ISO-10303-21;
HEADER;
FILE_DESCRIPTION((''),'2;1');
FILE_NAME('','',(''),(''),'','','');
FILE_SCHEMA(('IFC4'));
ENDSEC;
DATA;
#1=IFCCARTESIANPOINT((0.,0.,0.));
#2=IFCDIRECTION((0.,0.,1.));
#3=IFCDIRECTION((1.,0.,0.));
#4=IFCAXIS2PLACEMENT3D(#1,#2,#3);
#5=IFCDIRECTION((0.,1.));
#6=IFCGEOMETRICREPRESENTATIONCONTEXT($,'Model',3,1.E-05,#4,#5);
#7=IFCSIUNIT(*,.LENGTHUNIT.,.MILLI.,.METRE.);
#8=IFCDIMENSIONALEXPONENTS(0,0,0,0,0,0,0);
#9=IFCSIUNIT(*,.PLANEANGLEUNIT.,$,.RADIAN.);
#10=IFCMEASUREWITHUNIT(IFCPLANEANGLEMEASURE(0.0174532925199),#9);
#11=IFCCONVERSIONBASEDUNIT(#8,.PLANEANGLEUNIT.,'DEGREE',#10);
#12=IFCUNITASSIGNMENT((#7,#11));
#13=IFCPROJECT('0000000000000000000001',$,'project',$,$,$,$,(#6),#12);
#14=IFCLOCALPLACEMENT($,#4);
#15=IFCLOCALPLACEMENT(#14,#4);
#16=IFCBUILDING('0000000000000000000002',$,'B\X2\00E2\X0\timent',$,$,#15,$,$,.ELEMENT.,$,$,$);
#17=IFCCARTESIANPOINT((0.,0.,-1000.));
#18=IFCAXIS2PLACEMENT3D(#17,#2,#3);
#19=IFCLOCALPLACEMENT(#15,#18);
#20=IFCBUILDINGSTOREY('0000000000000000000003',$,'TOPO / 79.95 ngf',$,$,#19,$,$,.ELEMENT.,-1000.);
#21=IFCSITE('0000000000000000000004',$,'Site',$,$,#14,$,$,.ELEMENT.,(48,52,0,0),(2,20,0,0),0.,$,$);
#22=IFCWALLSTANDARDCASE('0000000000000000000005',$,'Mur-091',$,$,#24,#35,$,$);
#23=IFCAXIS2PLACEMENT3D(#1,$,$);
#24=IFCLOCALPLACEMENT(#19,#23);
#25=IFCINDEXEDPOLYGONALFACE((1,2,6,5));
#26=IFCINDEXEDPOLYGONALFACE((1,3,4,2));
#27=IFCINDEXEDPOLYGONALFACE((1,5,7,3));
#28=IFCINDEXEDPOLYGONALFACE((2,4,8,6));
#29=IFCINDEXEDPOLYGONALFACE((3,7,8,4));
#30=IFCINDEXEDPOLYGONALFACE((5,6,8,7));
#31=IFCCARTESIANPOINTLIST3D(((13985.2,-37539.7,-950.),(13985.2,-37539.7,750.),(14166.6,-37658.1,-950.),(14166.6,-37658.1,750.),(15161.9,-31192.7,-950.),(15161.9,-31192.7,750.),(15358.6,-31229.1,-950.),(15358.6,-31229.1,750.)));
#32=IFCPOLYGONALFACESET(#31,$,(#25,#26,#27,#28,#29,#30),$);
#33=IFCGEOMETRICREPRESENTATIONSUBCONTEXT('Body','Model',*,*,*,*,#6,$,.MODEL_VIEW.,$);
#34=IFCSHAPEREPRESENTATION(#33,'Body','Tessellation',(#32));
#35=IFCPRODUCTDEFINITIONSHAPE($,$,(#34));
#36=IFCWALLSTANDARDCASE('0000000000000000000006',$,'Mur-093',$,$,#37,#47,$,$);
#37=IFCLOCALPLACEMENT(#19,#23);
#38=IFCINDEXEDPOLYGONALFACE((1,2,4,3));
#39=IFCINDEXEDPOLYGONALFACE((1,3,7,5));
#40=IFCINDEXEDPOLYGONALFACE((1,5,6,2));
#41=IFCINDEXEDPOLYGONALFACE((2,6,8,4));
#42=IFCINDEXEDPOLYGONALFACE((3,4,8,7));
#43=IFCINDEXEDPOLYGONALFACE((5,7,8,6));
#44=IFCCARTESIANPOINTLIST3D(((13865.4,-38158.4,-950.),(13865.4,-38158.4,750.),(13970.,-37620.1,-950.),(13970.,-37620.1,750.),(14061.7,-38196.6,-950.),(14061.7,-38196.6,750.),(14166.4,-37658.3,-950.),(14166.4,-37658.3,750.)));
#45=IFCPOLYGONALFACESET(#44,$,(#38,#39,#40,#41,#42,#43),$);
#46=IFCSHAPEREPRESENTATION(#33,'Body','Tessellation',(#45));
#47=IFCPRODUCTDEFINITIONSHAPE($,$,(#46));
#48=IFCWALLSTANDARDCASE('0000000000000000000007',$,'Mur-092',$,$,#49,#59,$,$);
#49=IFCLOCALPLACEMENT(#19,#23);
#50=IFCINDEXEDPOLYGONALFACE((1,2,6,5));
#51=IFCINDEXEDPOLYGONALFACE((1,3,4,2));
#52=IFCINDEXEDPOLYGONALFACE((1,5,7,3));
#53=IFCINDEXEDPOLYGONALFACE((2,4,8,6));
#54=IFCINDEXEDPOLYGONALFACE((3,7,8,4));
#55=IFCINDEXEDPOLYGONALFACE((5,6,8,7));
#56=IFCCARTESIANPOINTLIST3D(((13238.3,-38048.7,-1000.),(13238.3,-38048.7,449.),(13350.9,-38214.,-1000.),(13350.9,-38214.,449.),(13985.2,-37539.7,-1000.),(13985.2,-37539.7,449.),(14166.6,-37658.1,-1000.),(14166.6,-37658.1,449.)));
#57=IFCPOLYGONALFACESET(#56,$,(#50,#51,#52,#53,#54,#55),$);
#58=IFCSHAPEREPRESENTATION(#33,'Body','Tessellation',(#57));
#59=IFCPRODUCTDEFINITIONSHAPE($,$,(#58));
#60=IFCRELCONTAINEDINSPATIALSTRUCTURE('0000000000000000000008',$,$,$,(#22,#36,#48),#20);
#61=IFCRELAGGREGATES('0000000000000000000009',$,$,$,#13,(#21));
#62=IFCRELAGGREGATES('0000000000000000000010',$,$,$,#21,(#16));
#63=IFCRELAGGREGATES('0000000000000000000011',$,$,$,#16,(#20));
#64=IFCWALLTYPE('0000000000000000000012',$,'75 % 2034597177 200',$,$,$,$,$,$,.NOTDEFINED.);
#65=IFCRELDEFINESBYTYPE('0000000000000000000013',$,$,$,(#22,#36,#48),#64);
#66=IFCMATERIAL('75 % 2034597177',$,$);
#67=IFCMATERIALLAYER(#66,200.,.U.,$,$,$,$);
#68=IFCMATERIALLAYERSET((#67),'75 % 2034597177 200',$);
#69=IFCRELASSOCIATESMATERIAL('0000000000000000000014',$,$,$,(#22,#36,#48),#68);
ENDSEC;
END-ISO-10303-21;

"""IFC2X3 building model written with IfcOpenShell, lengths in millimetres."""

from ifc_helpers import new_model, entity, si_unit, converted_unit, direction, frame, origin_with_axes, place, context, subcontext, project, spatial, polyline, outline, extrude, material, layer, layer_set, layer_usage, type_object, element, save


model = new_model("IFC2X3")

# Units and contexts
model_context = context("Model", 3, precision=1e-05, world=origin_with_axes(), true_north=direction((0.0, 1.0)))
body_context = subcontext(model_context, "Body", "Model", "MODEL_VIEW")
ifc_project = project(units=[si_unit("LENGTHUNIT", "METRE", prefix="MILLI"), converted_unit("PLANEANGLEUNIT", "DEGREE", entity("IfcPlaneAngleMeasure", 0.0174532925199), si_unit("PLANEANGLEUNIT", "RADIAN"), dimensions=[0, 0, 0, 0, 0, 0, 0])], contexts=[model_context])

# Site, building, storey
site_placement = place(None, origin_with_axes())
site = spatial("IfcSite", under=ifc_project, at=site_placement, Name="Site", CompositionType="ELEMENT", RefLatitude=(48, 52, 0, 0), RefLongitude=(2, 20, 0, 0), RefElevation=0.0)
building_placement = place(site_placement, origin_with_axes())
building = spatial("IfcBuilding", under=site, at=building_placement, Name="Bâtiment", CompositionType="ELEMENT")
storey_placement = place(building_placement, frame((0.0, 0.0, -1000.0), z_axis=(0.0, 0.0, 1.0), x_axis=(1.0, 0.0, 0.0)))
storey = spatial("IfcBuildingStorey", under=building, at=storey_placement, Name="TOPO / 79.95 ngf", CompositionType="ELEMENT", Elevation=-1000.0)

# Walls
ifc_material_1 = material(Name="75 % 2034597177")
ifc_layer_1 = layer(ifc_material_1, 200.0, ventilated="UNKNOWN")
ifc_layer_set_1 = layer_set([ifc_layer_1], Name="75 % 2034597177 200")
ifc_layer_usage_1 = layer_usage(ifc_layer_set_1, "AXIS2", "NEGATIVE", 200.0)
wall_type_1 = type_object("IfcWallType", Name="75 % 2034597177 200", PredefinedType="NOTDEFINED")
wall_1_placement = place(storey_placement, frame((15161.9, -31192.7, -950.0), z_axis=(0.0, 0.0, 1.0), x_axis=(-0.182296, -0.983244, 0.0)))
element("IfcWallStandardCase", 1, at=wall_1_placement, inside=storey, type_object=wall_type_1, material=ifc_layer_usage_1, Name="Mur-091", context=body_context, shape_type="SweptSolid", body=[
    extrude(outline(polyline([(0.0, 0.0), (6455.2, 0.0), (6538.5, 200.0), (0.0, 200.0), (0.0, 0.0)])), origin_with_axes(), (0.0, 0.0, 1.0), 1700.0),
])
ifc_layer_usage_2 = layer_usage(ifc_layer_set_1, "AXIS2", "POSITIVE", -200.0)
wall_2_placement = place(storey_placement, frame((14166.4, -37658.3, -950.0), z_axis=(0.0, 0.0, 1.0), x_axis=(-0.190862, -0.981617, 0.0)))
element("IfcWallStandardCase", 2, at=wall_2_placement, inside=storey, type_object=wall_type_1, material=ifc_layer_usage_2, Name="Mur-093", context=body_context, shape_type="SweptSolid", body=[
    extrude(outline(polyline([(0.0, -200.0), (548.4, -200.0), (548.4, 0.0), (0.0, 0.0), (0.0, -200.0)])), origin_with_axes(), (0.0, 0.0, 1.0), 1700.0),
])
ifc_layer_usage_3 = layer_usage(ifc_layer_set_1, "AXIS2", "NEGATIVE", 200.0)
wall_3_placement = place(storey_placement, frame((13985.2, -37539.7, -1000.0), z_axis=(0.0, 0.0, 1.0), x_axis=(-0.826372, -0.563124, 0.0)))
element("IfcWallStandardCase", 3, at=wall_3_placement, inside=storey, type_object=wall_type_1, material=ifc_layer_usage_3, Name="Mur-092", context=body_context, shape_type="SweptSolid", body=[
    extrude(outline(polyline([(0.0, 0.0), (903.9, 0.0), (903.9, 200.0), (-83.3, 200.0), (0.0, 0.0)])), origin_with_axes(), (0.0, 0.0, 1.0), 1449.0),
])

save(model, "model.ifc")
